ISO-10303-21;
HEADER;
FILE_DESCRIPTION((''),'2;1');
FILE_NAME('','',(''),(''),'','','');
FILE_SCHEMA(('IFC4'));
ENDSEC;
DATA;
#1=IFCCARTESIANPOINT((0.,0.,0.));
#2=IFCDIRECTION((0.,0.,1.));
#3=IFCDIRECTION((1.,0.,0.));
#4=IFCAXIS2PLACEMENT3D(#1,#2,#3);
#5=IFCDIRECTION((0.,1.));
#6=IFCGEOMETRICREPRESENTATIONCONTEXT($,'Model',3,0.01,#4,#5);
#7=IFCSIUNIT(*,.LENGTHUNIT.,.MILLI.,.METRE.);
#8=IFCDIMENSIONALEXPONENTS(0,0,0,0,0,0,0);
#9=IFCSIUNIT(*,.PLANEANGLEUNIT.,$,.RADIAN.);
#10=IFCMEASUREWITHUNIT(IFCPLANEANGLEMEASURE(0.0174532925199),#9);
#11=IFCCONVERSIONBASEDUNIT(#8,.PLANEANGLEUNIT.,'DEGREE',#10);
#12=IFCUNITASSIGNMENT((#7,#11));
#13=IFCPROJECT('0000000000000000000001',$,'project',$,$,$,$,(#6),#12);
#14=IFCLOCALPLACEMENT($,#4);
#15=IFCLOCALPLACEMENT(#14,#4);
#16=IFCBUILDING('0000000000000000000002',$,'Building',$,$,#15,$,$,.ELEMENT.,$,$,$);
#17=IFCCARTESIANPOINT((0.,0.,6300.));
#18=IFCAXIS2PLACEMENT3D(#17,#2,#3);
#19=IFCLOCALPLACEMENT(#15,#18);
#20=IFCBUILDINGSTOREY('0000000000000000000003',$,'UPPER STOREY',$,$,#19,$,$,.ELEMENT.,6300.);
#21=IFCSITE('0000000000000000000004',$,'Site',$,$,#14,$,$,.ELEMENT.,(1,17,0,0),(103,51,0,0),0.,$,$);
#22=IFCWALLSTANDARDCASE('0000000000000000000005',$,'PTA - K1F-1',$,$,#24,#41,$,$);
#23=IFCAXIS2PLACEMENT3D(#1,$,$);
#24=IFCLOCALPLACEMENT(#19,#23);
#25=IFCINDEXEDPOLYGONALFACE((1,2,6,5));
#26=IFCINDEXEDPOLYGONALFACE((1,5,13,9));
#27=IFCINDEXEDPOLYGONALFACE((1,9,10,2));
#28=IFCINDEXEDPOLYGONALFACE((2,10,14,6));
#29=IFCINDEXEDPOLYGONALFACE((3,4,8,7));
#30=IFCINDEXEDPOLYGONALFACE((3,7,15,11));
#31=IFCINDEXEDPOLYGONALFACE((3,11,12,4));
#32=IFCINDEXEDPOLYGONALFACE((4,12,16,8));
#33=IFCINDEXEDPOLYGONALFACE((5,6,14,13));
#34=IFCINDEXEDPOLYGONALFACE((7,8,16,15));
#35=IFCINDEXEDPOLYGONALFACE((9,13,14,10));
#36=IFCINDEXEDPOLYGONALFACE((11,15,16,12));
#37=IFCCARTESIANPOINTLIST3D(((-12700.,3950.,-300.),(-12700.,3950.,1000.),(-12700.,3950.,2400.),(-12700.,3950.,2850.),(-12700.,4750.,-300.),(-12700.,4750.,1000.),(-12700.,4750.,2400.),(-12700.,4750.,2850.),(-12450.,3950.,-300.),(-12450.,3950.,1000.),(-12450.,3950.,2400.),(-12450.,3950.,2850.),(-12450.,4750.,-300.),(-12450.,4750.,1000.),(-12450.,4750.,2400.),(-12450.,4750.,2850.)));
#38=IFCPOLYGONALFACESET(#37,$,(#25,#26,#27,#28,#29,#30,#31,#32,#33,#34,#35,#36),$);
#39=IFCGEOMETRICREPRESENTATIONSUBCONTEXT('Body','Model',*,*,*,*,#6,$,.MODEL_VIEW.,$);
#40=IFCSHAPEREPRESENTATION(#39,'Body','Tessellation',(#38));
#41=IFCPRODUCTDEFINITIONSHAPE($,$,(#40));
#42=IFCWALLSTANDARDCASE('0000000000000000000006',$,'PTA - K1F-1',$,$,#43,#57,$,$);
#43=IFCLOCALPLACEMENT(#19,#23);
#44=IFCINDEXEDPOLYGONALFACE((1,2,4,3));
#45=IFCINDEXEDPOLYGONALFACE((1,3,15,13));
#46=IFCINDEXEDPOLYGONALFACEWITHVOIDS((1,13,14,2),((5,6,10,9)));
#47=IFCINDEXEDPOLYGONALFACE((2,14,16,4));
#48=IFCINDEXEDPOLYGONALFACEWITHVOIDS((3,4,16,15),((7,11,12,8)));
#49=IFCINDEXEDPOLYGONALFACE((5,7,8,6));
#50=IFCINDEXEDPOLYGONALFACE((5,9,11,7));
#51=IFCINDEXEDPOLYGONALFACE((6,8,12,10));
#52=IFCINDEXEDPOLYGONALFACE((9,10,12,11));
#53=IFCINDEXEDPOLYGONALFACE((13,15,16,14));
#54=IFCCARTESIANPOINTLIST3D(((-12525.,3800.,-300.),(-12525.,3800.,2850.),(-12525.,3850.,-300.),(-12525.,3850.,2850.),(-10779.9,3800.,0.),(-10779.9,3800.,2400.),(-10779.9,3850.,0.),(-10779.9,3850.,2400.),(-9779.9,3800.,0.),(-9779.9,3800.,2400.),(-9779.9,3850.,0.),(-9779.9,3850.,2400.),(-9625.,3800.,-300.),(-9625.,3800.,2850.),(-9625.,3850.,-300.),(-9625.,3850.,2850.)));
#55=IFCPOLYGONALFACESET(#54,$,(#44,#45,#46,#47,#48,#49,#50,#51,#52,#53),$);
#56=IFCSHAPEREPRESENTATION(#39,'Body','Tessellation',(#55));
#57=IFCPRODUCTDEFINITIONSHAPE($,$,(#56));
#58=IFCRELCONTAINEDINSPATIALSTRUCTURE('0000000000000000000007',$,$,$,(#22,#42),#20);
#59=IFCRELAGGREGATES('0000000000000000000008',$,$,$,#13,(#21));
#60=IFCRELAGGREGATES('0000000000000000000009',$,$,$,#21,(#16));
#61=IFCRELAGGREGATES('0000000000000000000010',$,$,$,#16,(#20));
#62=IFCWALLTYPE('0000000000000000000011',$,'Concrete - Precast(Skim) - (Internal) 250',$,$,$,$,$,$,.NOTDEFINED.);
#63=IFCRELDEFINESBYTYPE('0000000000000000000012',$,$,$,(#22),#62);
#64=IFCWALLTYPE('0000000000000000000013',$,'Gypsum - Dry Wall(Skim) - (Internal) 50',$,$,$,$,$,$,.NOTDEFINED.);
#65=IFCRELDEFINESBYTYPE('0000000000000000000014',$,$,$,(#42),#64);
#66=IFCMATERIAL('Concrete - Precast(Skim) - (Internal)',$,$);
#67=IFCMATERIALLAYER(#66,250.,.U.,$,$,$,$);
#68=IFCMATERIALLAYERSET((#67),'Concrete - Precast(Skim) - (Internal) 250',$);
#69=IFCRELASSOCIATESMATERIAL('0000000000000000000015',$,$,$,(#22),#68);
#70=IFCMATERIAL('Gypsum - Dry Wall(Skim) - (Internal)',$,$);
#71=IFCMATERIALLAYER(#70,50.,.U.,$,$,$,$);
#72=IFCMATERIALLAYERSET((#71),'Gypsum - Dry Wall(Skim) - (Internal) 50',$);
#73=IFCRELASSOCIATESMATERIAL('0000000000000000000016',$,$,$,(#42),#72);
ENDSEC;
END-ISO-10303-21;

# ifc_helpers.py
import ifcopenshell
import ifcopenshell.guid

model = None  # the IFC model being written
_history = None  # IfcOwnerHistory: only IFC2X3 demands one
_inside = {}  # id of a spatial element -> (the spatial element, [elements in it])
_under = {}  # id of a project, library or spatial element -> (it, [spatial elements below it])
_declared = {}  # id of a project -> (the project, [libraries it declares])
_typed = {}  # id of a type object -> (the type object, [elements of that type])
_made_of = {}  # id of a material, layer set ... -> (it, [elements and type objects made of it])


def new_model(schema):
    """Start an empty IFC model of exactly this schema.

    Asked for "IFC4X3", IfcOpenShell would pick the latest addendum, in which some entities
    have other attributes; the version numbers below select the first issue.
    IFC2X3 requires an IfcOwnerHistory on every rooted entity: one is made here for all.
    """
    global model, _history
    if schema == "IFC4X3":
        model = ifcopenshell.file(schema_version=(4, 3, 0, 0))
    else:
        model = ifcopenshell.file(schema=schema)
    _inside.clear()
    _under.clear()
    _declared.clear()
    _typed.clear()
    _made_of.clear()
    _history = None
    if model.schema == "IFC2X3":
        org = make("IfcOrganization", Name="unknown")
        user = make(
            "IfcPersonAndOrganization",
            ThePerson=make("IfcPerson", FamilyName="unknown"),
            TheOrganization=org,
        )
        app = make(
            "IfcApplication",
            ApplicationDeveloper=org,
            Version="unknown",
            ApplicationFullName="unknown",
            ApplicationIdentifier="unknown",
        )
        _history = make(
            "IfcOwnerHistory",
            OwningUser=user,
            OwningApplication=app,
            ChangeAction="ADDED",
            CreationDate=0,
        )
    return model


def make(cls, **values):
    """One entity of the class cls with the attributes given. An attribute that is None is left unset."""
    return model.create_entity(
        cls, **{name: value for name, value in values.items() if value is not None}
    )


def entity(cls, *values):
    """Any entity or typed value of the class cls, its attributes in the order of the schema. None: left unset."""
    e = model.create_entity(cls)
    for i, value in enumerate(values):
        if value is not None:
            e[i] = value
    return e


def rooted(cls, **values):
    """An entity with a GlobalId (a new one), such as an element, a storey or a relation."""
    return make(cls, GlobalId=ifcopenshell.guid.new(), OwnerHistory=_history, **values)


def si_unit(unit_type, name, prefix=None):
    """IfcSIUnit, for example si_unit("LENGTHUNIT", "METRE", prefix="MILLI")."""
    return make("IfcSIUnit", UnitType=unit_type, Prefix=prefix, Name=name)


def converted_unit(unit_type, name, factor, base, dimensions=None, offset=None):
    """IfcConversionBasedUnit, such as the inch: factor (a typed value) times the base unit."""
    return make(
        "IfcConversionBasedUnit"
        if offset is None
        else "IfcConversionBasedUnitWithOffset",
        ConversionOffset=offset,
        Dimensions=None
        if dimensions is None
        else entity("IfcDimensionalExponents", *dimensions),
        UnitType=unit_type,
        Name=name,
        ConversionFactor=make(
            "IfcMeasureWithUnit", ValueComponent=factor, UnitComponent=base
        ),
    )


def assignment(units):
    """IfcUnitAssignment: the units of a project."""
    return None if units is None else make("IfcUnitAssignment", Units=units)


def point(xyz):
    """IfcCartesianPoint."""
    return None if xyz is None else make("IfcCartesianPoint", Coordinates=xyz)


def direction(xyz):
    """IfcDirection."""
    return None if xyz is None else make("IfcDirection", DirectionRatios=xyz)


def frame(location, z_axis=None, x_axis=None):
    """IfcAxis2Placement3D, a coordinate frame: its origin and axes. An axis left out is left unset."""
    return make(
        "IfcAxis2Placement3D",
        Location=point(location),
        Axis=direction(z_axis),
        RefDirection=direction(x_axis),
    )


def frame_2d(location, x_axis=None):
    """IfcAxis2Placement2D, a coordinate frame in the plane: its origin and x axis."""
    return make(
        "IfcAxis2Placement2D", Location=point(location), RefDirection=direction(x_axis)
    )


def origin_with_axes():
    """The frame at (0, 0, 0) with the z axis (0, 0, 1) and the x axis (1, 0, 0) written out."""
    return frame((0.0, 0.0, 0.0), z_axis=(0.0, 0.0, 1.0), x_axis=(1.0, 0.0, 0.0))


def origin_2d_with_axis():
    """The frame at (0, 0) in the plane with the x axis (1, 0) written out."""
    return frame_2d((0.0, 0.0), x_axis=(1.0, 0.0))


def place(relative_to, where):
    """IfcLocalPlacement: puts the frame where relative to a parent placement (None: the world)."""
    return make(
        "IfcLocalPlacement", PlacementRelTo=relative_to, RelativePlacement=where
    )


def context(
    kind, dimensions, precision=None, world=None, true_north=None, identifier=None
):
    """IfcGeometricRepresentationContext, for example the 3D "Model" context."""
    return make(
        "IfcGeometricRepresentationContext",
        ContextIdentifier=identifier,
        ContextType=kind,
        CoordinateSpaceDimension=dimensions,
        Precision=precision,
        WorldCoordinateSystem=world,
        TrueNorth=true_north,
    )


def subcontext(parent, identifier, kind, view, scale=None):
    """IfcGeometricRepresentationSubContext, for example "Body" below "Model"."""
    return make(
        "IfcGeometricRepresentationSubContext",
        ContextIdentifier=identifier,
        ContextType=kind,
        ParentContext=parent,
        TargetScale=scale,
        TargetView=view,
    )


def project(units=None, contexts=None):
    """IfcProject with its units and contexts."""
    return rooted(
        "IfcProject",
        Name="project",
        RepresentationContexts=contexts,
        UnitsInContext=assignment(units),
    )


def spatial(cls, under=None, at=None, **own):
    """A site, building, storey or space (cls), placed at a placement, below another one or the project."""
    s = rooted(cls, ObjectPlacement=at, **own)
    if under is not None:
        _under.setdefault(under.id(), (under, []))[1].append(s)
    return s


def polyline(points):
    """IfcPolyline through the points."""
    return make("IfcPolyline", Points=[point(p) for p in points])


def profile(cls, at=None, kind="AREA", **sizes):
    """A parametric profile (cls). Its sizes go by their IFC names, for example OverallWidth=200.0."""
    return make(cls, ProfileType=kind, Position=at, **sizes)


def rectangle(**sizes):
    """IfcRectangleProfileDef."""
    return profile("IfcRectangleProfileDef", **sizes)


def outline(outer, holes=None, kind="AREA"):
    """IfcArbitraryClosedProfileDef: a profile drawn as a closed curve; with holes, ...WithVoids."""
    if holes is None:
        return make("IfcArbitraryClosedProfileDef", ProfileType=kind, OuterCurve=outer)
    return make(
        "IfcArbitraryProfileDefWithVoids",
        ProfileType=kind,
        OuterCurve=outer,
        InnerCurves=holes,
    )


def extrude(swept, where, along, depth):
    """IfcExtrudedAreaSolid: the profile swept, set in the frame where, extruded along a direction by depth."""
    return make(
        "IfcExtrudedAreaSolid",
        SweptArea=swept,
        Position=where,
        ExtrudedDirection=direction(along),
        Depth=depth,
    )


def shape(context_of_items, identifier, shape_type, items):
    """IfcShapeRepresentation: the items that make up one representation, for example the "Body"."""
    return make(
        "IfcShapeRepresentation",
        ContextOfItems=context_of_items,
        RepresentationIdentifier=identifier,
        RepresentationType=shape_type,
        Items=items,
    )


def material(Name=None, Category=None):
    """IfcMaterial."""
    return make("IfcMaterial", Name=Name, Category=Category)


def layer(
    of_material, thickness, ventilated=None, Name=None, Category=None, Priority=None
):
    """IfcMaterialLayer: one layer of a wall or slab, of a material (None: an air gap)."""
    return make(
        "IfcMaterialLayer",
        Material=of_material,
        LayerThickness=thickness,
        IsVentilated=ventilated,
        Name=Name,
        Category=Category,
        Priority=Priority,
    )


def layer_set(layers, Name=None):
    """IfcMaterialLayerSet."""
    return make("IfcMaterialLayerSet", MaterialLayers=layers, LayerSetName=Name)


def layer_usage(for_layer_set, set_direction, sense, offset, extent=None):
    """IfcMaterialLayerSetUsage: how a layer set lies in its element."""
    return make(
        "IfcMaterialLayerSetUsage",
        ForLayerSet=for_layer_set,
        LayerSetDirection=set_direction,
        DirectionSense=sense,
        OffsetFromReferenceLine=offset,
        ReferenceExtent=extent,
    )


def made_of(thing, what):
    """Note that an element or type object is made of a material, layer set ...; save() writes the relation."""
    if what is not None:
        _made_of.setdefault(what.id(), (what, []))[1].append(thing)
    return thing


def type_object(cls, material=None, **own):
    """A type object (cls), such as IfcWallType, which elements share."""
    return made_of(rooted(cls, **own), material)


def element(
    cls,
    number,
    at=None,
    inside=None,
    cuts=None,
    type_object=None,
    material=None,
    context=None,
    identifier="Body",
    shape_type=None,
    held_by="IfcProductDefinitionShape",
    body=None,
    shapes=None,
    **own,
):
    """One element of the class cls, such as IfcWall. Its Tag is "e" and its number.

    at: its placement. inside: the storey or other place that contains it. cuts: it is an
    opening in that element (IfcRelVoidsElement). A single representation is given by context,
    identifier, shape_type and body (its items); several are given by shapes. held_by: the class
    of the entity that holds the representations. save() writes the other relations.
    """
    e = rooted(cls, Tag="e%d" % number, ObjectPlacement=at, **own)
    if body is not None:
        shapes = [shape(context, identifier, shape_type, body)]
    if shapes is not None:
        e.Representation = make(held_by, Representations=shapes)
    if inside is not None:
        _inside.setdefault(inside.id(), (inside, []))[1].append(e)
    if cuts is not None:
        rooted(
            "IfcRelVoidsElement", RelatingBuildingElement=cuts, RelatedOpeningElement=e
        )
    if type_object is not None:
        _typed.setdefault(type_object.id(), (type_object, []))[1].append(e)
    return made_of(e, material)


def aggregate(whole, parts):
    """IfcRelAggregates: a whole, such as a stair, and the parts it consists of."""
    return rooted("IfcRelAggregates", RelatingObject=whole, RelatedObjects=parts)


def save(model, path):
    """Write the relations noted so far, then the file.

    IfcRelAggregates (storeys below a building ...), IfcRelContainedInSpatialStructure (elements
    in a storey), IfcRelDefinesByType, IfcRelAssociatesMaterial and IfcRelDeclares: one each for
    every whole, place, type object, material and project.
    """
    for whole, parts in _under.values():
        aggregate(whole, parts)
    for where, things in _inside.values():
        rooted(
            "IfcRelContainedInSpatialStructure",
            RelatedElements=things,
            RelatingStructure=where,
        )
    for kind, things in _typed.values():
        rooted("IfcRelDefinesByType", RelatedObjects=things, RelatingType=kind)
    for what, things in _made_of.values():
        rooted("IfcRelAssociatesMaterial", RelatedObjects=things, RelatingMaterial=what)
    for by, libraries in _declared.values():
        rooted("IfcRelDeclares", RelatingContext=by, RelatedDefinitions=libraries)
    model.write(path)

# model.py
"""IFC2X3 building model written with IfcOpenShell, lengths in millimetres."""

from ifc_helpers import new_model, entity, si_unit, converted_unit, direction, frame, origin_with_axes, origin_2d_with_axis, place, context, subcontext, project, spatial, polyline, rectangle, outline, extrude, material, layer, layer_set, layer_usage, type_object, element, save


model = new_model("IFC2X3")

# Units and contexts
model_context = context("Model", 3, precision=0.01, world=origin_with_axes(), true_north=direction((0.0, 1.0)))
body_context = subcontext(model_context, "Body", "Model", "MODEL_VIEW")
ifc_project = project(units=[si_unit("LENGTHUNIT", "METRE", prefix="MILLI"), converted_unit("PLANEANGLEUNIT", "DEGREE", entity("IfcPlaneAngleMeasure", 0.0174532925199), si_unit("PLANEANGLEUNIT", "RADIAN"), dimensions=[0, 0, 0, 0, 0, 0, 0])], contexts=[model_context])

# Site, building, storey
site_placement = place(None, origin_with_axes())
site = spatial("IfcSite", under=ifc_project, at=site_placement, Name="Site", CompositionType="ELEMENT", RefLatitude=(1, 17, 0, 0), RefLongitude=(103, 51, 0, 0), RefElevation=0.0)
building_placement = place(site_placement, origin_with_axes())
building = spatial("IfcBuilding", under=site, at=building_placement, Name="Building", CompositionType="ELEMENT")
storey_placement = place(building_placement, frame((0.0, 0.0, 6300.0), z_axis=(0.0, 0.0, 1.0), x_axis=(1.0, 0.0, 0.0)))
storey = spatial("IfcBuildingStorey", under=building, at=storey_placement, Name="UPPER STOREY", CompositionType="ELEMENT", Elevation=6300.0)

# Shared definitions
ifc_material_1 = material(Name="Concrete - Precast(Skim) - (Internal)")

# Wall, opening
ifc_layer_1 = layer(ifc_material_1, 250.0, ventilated="UNKNOWN")
ifc_layer_set_1 = layer_set([ifc_layer_1], Name="Concrete - Precast(Skim) - (Internal) 250")
ifc_layer_usage_1 = layer_usage(ifc_layer_set_1, "AXIS2", "NEGATIVE", 0.0)
wall_type_1 = type_object("IfcWallType", Name="Concrete - Precast(Skim) - (Internal) 250", PredefinedType="NOTDEFINED")
wall_1_placement = place(storey_placement, frame((-12700.0, 3950.0, -300.0), z_axis=(0.0, 0.0, 1.0), x_axis=(0.0, 1.0, 0.0)))
wall_1 = element("IfcWallStandardCase", 1, at=wall_1_placement, inside=storey, type_object=wall_type_1, material=ifc_layer_usage_1, Name="PTA - K1F-1", context=body_context, shape_type="SweptSolid", body=[
    extrude(outline(polyline([(0.0, -250.0), (800.0, -250.0), (800.0, 0.0), (0.0, 0.0), (0.0, -250.0)])), origin_with_axes(), (0.0, 0.0, 1.0), 3150.0),
])
opening_1_placement = place(wall_1_placement, frame((400.0, 0.0, 1300.0), z_axis=(0.0, 0.0, 1.0), x_axis=(1.0, 0.0, 0.0)))
element("IfcOpeningElement", 2, at=opening_1_placement, cuts=wall_1, context=body_context, shape_type="SweptSolid", body=[
    extrude(rectangle(XDim=800.0, YDim=1400.0, at=origin_2d_with_axis()), frame((0.0, -250.0, 700.0), z_axis=(0.0, -1.0, 0.0), x_axis=(-1.0, 0.0, 0.0)), (0.0, 0.0, -1.0), 750.0),
])

# Wall, opening
ifc_material_2 = material(Name="Gypsum - Dry Wall(Skim) - (Internal)")
ifc_layer_2 = layer(ifc_material_2, 50.0, ventilated="UNKNOWN")
ifc_layer_set_2 = layer_set([ifc_layer_2], Name="Gypsum - Dry Wall(Skim) - (Internal) 50")
ifc_layer_usage_2 = layer_usage(ifc_layer_set_2, "AXIS2", "NEGATIVE", 0.0)
wall_type_2 = type_object("IfcWallType", Name="Gypsum - Dry Wall(Skim) - (Internal) 50", PredefinedType="NOTDEFINED")
wall_2_placement = place(storey_placement, frame((-9625.0, 3800.0, -300.0), z_axis=(0.0, 0.0, 1.0), x_axis=(-1.0, 0.000007, 0.0)))
wall_2 = element("IfcWallStandardCase", 3, at=wall_2_placement, inside=storey, type_object=wall_type_2, material=ifc_layer_usage_2, Name="PTA - K1F-1", context=body_context, shape_type="SweptSolid", body=[
    extrude(outline(polyline([(0.0, -50.0), (2900.0, -50.0), (2900.0, 0.0), (0.0, 0.0), (0.0, -50.0)])), origin_with_axes(), (0.0, 0.0, 1.0), 3150.0),
])
opening_2_placement = place(wall_2_placement, frame((654.9, 0.0, 300.0), z_axis=(0.0, 0.0, 1.0), x_axis=(1.0, 0.0, 0.0)))
element("IfcOpeningElement", 4, at=opening_2_placement, cuts=wall_2, context=body_context, shape_type="SweptSolid", body=[
    extrude(rectangle(XDim=1000.0, YDim=2400.0, at=origin_2d_with_axis()), frame((0.0, 0.0, 1200.0), z_axis=(0.0, -1.0, 0.0), x_axis=(1.0, 0.0, 0.0)), (0.0, 0.0, -1.0), 50.0),
    extrude(rectangle(XDim=1000.0, YDim=2400.0, at=origin_2d_with_axis()), frame((0.0, 0.0, 1200.0), z_axis=(0.0, 1.0, 0.0), x_axis=(1.0, 0.0, 0.0)), (0.0, 0.0, -1.0), 50.0),
])

save(model, "model.ifc")
